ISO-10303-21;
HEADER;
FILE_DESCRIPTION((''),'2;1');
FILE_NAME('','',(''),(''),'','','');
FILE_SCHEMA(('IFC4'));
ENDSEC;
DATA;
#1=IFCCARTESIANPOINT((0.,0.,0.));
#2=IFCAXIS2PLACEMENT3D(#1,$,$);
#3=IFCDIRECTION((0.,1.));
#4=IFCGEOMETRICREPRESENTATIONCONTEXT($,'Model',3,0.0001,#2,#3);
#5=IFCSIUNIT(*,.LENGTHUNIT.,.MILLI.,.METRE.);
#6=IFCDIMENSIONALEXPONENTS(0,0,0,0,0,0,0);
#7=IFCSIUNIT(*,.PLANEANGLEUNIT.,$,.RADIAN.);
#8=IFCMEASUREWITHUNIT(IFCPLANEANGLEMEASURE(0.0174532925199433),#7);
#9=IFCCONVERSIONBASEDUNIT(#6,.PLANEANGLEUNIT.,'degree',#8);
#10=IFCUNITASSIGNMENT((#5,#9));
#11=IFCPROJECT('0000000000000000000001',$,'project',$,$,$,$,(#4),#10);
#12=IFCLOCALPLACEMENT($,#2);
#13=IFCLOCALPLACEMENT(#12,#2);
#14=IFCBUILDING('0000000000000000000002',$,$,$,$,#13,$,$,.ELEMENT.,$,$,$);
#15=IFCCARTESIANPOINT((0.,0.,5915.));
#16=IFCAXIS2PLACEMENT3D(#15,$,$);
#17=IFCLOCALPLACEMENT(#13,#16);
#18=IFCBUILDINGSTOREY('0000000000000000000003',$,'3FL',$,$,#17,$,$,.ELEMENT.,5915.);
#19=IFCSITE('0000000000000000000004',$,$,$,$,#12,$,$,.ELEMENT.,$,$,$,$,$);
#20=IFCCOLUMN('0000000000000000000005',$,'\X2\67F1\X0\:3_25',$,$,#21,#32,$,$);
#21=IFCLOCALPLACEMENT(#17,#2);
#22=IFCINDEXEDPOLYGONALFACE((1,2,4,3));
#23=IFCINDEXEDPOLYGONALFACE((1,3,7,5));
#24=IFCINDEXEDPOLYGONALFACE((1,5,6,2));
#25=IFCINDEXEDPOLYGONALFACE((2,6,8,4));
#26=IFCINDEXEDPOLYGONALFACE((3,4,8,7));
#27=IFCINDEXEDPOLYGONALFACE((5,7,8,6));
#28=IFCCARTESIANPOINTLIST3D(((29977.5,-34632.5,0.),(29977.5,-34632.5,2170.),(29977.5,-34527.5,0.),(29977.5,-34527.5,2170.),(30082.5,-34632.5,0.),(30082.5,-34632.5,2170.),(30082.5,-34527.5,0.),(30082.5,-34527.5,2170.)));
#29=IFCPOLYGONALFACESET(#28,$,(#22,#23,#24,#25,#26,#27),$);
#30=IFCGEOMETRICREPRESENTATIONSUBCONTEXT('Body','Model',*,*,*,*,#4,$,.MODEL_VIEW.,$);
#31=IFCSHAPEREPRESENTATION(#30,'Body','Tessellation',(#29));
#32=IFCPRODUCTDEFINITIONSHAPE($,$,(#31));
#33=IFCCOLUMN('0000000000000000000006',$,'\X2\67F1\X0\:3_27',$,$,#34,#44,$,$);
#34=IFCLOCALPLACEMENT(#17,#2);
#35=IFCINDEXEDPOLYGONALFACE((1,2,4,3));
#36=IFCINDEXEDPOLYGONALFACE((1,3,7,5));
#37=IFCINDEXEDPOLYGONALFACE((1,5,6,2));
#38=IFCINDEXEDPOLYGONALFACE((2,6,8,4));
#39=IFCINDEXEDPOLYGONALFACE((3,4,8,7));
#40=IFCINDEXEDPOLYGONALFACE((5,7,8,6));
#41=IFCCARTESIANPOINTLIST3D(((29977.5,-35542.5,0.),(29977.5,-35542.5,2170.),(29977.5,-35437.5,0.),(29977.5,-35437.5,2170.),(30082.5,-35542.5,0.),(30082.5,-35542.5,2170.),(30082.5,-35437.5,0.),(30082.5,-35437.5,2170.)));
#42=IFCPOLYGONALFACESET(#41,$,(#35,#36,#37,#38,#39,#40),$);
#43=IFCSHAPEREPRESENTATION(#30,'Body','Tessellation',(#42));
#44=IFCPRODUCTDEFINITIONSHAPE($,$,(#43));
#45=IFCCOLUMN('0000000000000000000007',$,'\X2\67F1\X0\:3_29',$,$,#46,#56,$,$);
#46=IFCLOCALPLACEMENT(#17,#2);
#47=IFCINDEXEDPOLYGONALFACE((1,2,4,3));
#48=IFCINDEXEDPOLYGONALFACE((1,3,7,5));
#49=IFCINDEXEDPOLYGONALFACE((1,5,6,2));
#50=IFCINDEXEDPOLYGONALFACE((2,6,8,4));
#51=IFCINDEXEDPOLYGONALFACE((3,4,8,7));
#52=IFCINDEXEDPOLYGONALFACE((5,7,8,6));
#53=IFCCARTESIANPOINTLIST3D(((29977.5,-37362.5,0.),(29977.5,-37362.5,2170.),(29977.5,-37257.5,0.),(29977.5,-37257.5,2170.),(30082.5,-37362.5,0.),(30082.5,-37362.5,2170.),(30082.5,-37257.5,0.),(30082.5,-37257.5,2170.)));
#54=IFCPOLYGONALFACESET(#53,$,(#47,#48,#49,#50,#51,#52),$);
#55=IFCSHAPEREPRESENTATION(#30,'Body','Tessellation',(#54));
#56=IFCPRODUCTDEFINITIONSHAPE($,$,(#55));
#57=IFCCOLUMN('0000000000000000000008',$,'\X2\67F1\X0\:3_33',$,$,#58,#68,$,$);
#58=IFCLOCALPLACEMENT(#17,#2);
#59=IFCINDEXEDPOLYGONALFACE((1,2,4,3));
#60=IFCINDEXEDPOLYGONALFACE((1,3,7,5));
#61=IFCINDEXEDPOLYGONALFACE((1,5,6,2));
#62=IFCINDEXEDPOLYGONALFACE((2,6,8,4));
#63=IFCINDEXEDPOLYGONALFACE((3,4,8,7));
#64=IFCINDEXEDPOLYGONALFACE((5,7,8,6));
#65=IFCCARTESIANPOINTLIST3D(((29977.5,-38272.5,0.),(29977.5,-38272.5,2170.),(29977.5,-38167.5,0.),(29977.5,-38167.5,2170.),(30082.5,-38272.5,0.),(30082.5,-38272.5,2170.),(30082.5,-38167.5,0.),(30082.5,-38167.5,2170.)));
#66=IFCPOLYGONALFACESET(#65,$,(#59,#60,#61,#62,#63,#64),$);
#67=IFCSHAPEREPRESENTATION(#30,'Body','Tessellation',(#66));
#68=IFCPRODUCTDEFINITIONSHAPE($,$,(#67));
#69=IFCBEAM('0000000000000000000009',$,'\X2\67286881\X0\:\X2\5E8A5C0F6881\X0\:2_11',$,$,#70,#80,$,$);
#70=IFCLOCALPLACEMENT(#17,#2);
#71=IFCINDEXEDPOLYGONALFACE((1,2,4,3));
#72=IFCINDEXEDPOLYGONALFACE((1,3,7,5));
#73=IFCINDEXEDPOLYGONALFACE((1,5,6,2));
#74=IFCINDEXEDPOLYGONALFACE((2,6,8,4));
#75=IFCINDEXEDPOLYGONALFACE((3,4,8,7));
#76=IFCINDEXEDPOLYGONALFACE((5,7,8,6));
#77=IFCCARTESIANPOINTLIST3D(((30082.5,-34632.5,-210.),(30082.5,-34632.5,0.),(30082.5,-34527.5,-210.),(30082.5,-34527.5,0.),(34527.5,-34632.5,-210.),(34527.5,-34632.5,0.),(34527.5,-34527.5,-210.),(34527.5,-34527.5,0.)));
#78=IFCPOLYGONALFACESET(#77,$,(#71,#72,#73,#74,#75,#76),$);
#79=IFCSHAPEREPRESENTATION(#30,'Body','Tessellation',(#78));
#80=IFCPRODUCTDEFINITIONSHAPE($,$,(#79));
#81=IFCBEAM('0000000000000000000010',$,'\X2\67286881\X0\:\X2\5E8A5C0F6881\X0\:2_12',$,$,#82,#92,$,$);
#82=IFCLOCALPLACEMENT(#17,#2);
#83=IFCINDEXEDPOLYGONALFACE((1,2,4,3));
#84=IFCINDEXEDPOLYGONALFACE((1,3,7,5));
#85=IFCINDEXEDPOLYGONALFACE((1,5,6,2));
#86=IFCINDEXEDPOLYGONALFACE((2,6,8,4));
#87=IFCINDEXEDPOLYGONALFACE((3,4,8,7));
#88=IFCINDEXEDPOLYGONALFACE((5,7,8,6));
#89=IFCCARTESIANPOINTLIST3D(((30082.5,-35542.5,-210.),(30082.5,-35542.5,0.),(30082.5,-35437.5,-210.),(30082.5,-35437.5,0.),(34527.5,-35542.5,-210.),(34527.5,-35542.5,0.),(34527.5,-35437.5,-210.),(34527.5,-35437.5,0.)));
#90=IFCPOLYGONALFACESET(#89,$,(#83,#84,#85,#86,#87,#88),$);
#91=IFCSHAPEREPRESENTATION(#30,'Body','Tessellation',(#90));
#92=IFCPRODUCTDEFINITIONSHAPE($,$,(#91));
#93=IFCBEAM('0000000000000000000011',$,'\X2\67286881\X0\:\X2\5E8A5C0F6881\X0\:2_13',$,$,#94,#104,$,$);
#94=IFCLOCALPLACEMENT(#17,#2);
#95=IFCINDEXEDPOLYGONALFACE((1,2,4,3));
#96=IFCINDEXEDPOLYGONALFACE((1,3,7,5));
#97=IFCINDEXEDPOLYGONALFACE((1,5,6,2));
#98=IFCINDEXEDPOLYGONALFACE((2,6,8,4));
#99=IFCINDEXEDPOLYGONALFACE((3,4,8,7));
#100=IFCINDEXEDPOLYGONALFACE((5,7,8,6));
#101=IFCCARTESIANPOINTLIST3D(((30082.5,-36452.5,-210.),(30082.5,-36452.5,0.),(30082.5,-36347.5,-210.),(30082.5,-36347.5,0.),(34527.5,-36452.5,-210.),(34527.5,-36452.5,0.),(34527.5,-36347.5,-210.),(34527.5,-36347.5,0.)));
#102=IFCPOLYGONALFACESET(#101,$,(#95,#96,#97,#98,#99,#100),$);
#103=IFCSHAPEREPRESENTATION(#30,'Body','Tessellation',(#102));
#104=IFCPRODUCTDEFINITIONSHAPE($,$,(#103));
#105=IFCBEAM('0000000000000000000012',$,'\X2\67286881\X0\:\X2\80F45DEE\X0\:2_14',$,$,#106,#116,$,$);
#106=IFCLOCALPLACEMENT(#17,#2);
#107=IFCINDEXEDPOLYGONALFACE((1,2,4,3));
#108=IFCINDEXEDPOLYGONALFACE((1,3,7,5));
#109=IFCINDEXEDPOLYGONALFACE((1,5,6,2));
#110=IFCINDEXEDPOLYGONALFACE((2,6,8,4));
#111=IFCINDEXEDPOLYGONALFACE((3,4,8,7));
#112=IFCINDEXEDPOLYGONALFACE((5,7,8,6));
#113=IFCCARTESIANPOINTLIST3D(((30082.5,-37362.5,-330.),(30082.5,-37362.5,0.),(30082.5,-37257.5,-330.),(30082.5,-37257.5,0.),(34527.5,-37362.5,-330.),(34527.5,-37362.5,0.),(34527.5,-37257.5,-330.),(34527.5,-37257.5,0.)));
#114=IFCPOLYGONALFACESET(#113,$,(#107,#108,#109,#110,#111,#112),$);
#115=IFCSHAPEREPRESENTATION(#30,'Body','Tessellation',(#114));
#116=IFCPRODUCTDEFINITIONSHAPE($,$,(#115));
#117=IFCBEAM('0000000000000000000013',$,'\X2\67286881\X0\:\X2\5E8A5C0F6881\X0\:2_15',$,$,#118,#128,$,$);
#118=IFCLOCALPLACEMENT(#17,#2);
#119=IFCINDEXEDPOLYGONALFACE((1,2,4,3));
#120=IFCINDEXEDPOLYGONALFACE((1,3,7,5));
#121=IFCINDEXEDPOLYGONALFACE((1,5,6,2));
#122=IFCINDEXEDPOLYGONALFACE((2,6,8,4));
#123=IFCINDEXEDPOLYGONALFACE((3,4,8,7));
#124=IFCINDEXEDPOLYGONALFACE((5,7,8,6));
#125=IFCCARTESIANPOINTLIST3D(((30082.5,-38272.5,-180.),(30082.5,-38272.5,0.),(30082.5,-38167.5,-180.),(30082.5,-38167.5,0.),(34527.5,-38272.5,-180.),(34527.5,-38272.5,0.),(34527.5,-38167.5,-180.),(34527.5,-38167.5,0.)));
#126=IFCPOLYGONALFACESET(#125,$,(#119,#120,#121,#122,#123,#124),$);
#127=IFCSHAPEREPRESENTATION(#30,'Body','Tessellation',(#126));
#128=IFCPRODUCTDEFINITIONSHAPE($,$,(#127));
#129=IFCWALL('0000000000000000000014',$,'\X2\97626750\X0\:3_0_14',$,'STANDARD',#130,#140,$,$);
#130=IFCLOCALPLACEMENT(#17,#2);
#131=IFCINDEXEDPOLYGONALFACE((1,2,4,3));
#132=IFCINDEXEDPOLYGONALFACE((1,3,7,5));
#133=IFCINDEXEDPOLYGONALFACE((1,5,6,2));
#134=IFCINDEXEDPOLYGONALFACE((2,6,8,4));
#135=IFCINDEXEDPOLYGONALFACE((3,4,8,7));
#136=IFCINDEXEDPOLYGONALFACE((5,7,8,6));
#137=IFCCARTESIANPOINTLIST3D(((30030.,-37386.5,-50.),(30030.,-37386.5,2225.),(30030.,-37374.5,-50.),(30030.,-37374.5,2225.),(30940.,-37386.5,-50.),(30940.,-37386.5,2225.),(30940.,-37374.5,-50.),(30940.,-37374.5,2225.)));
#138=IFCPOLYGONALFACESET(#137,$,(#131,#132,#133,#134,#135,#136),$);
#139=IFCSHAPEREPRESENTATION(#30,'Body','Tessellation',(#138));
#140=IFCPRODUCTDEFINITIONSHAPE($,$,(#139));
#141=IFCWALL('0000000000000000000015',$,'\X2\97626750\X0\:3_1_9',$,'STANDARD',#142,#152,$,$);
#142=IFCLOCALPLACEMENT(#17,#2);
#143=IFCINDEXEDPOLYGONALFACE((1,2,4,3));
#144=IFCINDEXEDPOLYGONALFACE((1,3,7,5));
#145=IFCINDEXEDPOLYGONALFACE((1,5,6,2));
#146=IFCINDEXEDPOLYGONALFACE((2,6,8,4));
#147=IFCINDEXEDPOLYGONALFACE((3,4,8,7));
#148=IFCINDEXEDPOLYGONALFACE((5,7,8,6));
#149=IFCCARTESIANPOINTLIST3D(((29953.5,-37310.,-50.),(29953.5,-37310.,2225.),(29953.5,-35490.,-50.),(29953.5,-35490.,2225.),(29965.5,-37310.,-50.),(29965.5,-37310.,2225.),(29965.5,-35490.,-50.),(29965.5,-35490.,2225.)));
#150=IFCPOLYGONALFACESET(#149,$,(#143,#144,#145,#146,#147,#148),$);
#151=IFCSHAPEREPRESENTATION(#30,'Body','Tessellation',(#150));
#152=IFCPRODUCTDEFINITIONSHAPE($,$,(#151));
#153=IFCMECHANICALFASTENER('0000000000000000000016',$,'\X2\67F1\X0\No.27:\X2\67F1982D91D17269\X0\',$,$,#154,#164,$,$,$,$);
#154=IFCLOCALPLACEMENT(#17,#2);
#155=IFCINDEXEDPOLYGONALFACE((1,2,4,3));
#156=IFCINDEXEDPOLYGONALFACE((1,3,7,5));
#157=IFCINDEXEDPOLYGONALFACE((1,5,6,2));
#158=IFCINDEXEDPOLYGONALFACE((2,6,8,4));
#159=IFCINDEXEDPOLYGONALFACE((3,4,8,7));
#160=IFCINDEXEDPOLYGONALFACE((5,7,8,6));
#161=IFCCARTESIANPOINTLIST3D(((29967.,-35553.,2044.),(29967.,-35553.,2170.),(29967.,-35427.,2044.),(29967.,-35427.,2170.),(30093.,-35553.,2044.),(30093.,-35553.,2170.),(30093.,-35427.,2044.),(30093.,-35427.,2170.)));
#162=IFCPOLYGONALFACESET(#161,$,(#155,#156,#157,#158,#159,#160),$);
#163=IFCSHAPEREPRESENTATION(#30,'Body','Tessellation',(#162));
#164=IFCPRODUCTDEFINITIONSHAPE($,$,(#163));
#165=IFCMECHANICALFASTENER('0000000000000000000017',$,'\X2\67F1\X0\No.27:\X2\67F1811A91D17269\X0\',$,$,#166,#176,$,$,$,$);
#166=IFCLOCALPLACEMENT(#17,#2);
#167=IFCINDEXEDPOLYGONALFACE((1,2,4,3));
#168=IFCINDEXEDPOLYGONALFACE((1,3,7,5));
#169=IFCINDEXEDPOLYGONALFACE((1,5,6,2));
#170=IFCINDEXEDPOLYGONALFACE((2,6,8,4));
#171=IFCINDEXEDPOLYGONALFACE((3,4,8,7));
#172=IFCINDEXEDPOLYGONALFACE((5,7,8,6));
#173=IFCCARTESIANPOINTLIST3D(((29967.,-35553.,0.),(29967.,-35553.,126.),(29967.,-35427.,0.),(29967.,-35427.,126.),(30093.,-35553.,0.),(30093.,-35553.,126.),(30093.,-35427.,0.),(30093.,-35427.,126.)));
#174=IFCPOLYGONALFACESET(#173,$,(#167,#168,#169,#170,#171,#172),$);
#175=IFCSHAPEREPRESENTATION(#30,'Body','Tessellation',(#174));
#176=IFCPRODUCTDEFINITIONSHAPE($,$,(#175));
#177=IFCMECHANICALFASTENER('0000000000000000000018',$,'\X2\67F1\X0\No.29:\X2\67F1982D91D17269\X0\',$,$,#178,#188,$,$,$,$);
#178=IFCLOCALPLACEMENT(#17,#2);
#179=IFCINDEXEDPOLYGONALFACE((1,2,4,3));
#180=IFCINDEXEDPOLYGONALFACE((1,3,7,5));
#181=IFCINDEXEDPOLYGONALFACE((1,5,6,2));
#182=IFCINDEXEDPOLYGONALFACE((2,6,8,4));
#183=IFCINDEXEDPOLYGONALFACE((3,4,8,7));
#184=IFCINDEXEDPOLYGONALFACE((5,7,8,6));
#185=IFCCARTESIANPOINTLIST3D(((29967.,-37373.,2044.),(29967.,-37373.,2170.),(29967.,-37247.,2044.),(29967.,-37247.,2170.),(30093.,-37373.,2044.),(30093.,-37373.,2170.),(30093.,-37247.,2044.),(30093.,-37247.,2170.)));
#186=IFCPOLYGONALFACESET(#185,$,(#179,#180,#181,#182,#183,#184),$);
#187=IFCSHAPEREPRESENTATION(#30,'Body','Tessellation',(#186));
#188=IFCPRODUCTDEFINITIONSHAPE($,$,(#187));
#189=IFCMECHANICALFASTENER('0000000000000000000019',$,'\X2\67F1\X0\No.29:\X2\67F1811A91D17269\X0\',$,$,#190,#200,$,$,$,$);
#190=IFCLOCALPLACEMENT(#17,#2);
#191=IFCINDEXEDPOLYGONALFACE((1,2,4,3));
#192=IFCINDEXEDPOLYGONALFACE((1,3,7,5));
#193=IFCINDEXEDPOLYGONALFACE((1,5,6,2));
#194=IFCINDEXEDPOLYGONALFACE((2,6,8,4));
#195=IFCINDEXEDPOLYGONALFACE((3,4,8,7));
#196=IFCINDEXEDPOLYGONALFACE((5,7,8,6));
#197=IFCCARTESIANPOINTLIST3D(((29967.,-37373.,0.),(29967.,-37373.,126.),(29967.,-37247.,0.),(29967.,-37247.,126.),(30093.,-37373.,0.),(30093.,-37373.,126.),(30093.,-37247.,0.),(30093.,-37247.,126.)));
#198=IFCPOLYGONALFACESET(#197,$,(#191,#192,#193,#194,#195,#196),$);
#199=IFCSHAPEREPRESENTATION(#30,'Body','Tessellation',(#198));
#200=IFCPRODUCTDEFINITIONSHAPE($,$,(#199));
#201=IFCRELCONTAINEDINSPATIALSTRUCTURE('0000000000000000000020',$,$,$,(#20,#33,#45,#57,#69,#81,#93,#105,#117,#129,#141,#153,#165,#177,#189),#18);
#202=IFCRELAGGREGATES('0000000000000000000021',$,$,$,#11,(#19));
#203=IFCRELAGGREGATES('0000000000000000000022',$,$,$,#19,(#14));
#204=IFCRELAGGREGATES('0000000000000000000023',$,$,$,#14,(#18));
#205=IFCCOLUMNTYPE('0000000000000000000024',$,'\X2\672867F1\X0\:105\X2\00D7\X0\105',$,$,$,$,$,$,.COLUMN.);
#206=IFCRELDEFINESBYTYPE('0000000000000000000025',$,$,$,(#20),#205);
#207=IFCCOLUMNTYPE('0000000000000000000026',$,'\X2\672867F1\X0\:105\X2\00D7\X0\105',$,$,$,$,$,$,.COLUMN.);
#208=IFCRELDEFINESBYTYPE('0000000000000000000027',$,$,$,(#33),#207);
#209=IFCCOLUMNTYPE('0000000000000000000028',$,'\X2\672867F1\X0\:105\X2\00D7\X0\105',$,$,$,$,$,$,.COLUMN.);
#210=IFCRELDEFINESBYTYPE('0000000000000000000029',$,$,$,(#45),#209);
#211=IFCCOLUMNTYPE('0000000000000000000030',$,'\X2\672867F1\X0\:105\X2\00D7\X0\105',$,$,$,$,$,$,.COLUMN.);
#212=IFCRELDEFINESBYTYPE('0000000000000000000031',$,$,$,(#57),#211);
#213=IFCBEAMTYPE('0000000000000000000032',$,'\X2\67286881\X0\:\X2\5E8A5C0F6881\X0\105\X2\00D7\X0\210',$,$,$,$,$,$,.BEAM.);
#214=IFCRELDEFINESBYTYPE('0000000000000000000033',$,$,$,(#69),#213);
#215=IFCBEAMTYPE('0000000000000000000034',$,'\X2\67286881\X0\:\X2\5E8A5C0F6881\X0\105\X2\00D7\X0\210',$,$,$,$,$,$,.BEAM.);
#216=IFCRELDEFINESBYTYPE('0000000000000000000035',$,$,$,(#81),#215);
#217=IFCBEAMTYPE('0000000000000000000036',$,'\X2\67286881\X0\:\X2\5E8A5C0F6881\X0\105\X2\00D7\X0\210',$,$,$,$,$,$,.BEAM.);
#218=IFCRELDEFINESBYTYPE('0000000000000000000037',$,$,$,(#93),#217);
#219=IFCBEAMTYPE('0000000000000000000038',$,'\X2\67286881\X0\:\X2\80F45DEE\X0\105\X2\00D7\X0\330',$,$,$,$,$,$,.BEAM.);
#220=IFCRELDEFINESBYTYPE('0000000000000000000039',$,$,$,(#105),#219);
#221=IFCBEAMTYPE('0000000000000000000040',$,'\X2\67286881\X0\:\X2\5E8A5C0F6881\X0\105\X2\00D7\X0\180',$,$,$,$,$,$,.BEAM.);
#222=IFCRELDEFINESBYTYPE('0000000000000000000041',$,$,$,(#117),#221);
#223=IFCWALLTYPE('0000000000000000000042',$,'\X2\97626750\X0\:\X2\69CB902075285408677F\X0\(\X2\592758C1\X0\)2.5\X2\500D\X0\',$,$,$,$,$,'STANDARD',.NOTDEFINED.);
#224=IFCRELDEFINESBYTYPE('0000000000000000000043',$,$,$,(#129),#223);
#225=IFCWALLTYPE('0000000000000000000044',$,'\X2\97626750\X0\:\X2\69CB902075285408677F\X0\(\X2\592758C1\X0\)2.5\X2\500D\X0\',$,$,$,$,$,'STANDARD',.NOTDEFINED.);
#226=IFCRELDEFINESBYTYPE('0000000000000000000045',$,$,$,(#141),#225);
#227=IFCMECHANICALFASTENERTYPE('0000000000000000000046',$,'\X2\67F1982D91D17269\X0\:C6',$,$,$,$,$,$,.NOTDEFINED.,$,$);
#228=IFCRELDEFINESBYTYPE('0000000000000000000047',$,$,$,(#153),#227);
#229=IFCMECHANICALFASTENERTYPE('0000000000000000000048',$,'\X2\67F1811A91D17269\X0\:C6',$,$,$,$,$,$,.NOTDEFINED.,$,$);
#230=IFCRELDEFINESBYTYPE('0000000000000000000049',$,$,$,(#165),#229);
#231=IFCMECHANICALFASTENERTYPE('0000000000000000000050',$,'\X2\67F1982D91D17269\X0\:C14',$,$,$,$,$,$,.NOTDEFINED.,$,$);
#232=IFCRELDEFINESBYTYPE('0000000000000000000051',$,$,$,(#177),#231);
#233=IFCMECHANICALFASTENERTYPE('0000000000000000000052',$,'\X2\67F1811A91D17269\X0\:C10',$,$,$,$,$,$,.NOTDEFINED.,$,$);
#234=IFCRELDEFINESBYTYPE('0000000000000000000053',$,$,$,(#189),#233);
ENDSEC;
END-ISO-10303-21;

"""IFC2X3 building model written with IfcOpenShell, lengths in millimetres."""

from ifc_helpers import new_model, entity, si_unit, converted_unit, direction, frame, origin, origin_with_axes, origin_2d, place, context, subcontext, project, spatial, polyline, rectangle, outline, extrude, type_object, element, save


model = new_model("IFC2X3")

# Units and contexts
model_context = context("Model", 3, precision=0.0001, world=origin(), true_north=direction((0.0, 1.0)))
body_context = subcontext(model_context, "Body", "Model", "MODEL_VIEW")
ifc_project = project(units=[si_unit("LENGTHUNIT", "METRE", prefix="MILLI"), converted_unit("PLANEANGLEUNIT", "degree", entity("IfcPlaneAngleMeasure", 0.0174532925199433), si_unit("PLANEANGLEUNIT", "RADIAN"), dimensions=[0, 0, 0, 0, 0, 0, 0])], contexts=[model_context])

# Site, building, storey
site_placement = place(None, origin())
site = spatial("IfcSite", under=ifc_project, at=site_placement, CompositionType="ELEMENT")
building_placement = place(site_placement, origin())
building = spatial("IfcBuilding", under=site, at=building_placement, CompositionType="ELEMENT")
storey_placement = place(building_placement, frame((0.0, 0.0, 5915.0)))
storey = spatial("IfcBuildingStorey", under=building, at=storey_placement, Name="3FL", CompositionType="ELEMENT", Elevation=5915.0)

# Columns
column_type_1 = type_object("IfcColumnType", Name="木柱:105×105", PredefinedType="COLUMN")
column_1_placement = place(storey_placement, frame((30030.0, -34580.0, 0.0)))
element("IfcColumn", 1, at=column_1_placement, inside=storey, type_object=column_type_1, Name="柱:3_25", context=body_context, shape_type="SweptSolid", body=[
    extrude(rectangle(XDim=105.0, YDim=105.0, at=origin_2d()), origin_with_axes(), (0.0, 0.0, 1.0), 2170.0),
])
column_type_2 = type_object("IfcColumnType", Name="木柱:105×105", PredefinedType="COLUMN")
column_2_placement = place(storey_placement, frame((30030.0, -35490.0, 0.0)))
element("IfcColumn", 2, at=column_2_placement, inside=storey, type_object=column_type_2, Name="柱:3_27", context=body_context, shape_type="SweptSolid", body=[
    extrude(rectangle(XDim=105.0, YDim=105.0, at=origin_2d()), origin_with_axes(), (0.0, 0.0, 1.0), 2170.0),
])
column_type_3 = type_object("IfcColumnType", Name="木柱:105×105", PredefinedType="COLUMN")
column_3_placement = place(storey_placement, frame((30030.0, -37310.0, 0.0)))
element("IfcColumn", 3, at=column_3_placement, inside=storey, type_object=column_type_3, Name="柱:3_29", context=body_context, shape_type="SweptSolid", body=[
    extrude(rectangle(XDim=105.0, YDim=105.0, at=origin_2d()), origin_with_axes(), (0.0, 0.0, 1.0), 2170.0),
])
column_type_4 = type_object("IfcColumnType", Name="木柱:105×105", PredefinedType="COLUMN")
column_4_placement = place(storey_placement, frame((30030.0, -38220.0, 0.0)))
element("IfcColumn", 4, at=column_4_placement, inside=storey, type_object=column_type_4, Name="柱:3_33", context=body_context, shape_type="SweptSolid", body=[
    extrude(rectangle(XDim=105.0, YDim=105.0, at=origin_2d()), origin_with_axes(), (0.0, 0.0, 1.0), 2170.0),
])

# Beams
beam_type_1 = type_object("IfcBeamType", Name="木梁:床小梁105×210", PredefinedType="BEAM")
beam_1_placement = place(storey_placement, frame((30082.5, -34580.0, -105.0), z_axis=(1.0, 0.0, 0.0), x_axis=(0.0, 1.0, 0.0)))
element("IfcBeam", 5, at=beam_1_placement, inside=storey, type_object=beam_type_1, Name="木梁:床小梁:2_11", context=body_context, shape_type="SweptSolid", body=[
    extrude(rectangle(XDim=105.0, YDim=210.0, at=origin_2d()), origin_with_axes(), (0.0, 0.0, 1.0), 4445.0),
])
beam_type_2 = type_object("IfcBeamType", Name="木梁:床小梁105×210", PredefinedType="BEAM")
beam_2_placement = place(storey_placement, frame((30082.5, -35490.0, -105.0), z_axis=(1.0, 0.0, 0.0), x_axis=(0.0, 1.0, 0.0)))
element("IfcBeam", 6, at=beam_2_placement, inside=storey, type_object=beam_type_2, Name="木梁:床小梁:2_12", context=body_context, shape_type="SweptSolid", body=[
    extrude(rectangle(XDim=105.0, YDim=210.0, at=origin_2d()), origin_with_axes(), (0.0, 0.0, 1.0), 4445.0),
])
beam_type_3 = type_object("IfcBeamType", Name="木梁:床小梁105×210", PredefinedType="BEAM")
beam_3_placement = place(storey_placement, frame((30082.5, -36400.0, -105.0), z_axis=(1.0, 0.0, 0.0), x_axis=(0.0, 1.0, 0.0)))
element("IfcBeam", 7, at=beam_3_placement, inside=storey, type_object=beam_type_3, Name="木梁:床小梁:2_13", context=body_context, shape_type="SweptSolid", body=[
    extrude(rectangle(XDim=105.0, YDim=210.0, at=origin_2d()), origin_with_axes(), (0.0, 0.0, 1.0), 4445.0),
])
beam_type_4 = type_object("IfcBeamType", Name="木梁:胴差105×330", PredefinedType="BEAM")
beam_4_placement = place(storey_placement, frame((30082.5, -37310.0, -165.0), z_axis=(1.0, 0.0, 0.0), x_axis=(0.0, 1.0, 0.0)))
element("IfcBeam", 8, at=beam_4_placement, inside=storey, type_object=beam_type_4, Name="木梁:胴差:2_14", context=body_context, shape_type="SweptSolid", body=[
    extrude(rectangle(XDim=105.0, YDim=330.0, at=origin_2d()), origin_with_axes(), (0.0, 0.0, 1.0), 4445.0),
])
beam_type_5 = type_object("IfcBeamType", Name="木梁:床小梁105×180", PredefinedType="BEAM")
beam_5_placement = place(storey_placement, frame((30082.5, -38220.0, -90.0), z_axis=(1.0, 0.0, 0.0), x_axis=(0.0, 1.0, 0.0)))
element("IfcBeam", 9, at=beam_5_placement, inside=storey, type_object=beam_type_5, Name="木梁:床小梁:2_15", context=body_context, shape_type="SweptSolid", body=[
    extrude(rectangle(XDim=105.0, YDim=180.0, at=origin_2d()), origin_with_axes(), (0.0, 0.0, 1.0), 4445.0),
])

# Walls
wall_type_1 = type_object("IfcWallType", Name="面材:構造用合板(大壁)2.5倍", ElementType="STANDARD", PredefinedType="NOTDEFINED")
wall_1_placement = place(storey_placement, frame((30485.0, -37374.5, -50.0), z_axis=(0.0, -1.0, 0.0), x_axis=(1.0, 0.0, 0.0)))
element("IfcWall", 10, at=wall_1_placement, inside=storey, type_object=wall_type_1, Name="面材:3_0_14", ObjectType="STANDARD", context=body_context, shape_type="SweptSolid", body=[
    extrude(outline(polyline([(455.0, 0.0, 0.0), (-455.0, 0.0, 0.0), (-455.0, 2275.0, 0.0), (455.0, 2275.0, 0.0), (455.0, 0.0, 0.0)])), origin_with_axes(), (0.0, 0.0, 1.0), 12.0),
])
wall_type_2 = type_object("IfcWallType", Name="面材:構造用合板(大壁)2.5倍", ElementType="STANDARD", PredefinedType="NOTDEFINED")
wall_2_placement = place(storey_placement, frame((29965.5, -36400.0, -50.0), z_axis=(-1.0, 0.0, 0.0), x_axis=(0.0, -1.0, 0.0)))
element("IfcWall", 11, at=wall_2_placement, inside=storey, type_object=wall_type_2, Name="面材:3_1_9", ObjectType="STANDARD", context=body_context, shape_type="SweptSolid", body=[
    extrude(outline(polyline([(910.0, 0.0, 0.0), (-910.0, 0.0, 0.0), (-910.0, 2275.0, 0.0), (910.0, 2275.0, 0.0), (910.0, 0.0, 0.0)])), origin_with_axes(), (0.0, 0.0, 1.0), 12.0),
])

# Mechanical fasteners
mechanical_fastener_type_1 = type_object("IfcMechanicalFastenerType", Name="柱頭金物:C6")
mechanical_fastener_1_placement = place(storey_placement, frame((30030.0, -35490.0, 2044.0)))
element("IfcMechanicalFastener", 12, at=mechanical_fastener_1_placement, inside=storey, type_object=mechanical_fastener_type_1, Name="柱No.27:柱頭金物", context=body_context, shape_type="SweptSolid", body=[
    extrude(rectangle(XDim=126.0, YDim=126.0, at=origin_2d()), origin_with_axes(), (0.0, 0.0, 1.0), 126.0),
])
mechanical_fastener_type_2 = type_object("IfcMechanicalFastenerType", Name="柱脚金物:C6")
mechanical_fastener_2_placement = place(storey_placement, frame((30030.0, -35490.0, 0.0)))
element("IfcMechanicalFastener", 13, at=mechanical_fastener_2_placement, inside=storey, type_object=mechanical_fastener_type_2, Name="柱No.27:柱脚金物", context=body_context, shape_type="SweptSolid", body=[
    extrude(rectangle(XDim=126.0, YDim=126.0, at=origin_2d()), origin_with_axes(), (0.0, 0.0, 1.0), 126.0),
])
mechanical_fastener_type_3 = type_object("IfcMechanicalFastenerType", Name="柱頭金物:C14")
mechanical_fastener_3_placement = place(storey_placement, frame((30030.0, -37310.0, 2044.0)))
element("IfcMechanicalFastener", 14, at=mechanical_fastener_3_placement, inside=storey, type_object=mechanical_fastener_type_3, Name="柱No.29:柱頭金物", context=body_context, shape_type="SweptSolid", body=[
    extrude(rectangle(XDim=126.0, YDim=126.0, at=origin_2d()), origin_with_axes(), (0.0, 0.0, 1.0), 126.0),
])
mechanical_fastener_type_4 = type_object("IfcMechanicalFastenerType", Name="柱脚金物:C10")
mechanical_fastener_4_placement = place(storey_placement, frame((30030.0, -37310.0, 0.0)))
element("IfcMechanicalFastener", 15, at=mechanical_fastener_4_placement, inside=storey, type_object=mechanical_fastener_type_4, Name="柱No.29:柱脚金物", context=body_context, shape_type="SweptSolid", body=[
    extrude(rectangle(XDim=126.0, YDim=126.0, at=origin_2d()), origin_with_axes(), (0.0, 0.0, 1.0), 126.0),
])

save(model, "model.ifc")
